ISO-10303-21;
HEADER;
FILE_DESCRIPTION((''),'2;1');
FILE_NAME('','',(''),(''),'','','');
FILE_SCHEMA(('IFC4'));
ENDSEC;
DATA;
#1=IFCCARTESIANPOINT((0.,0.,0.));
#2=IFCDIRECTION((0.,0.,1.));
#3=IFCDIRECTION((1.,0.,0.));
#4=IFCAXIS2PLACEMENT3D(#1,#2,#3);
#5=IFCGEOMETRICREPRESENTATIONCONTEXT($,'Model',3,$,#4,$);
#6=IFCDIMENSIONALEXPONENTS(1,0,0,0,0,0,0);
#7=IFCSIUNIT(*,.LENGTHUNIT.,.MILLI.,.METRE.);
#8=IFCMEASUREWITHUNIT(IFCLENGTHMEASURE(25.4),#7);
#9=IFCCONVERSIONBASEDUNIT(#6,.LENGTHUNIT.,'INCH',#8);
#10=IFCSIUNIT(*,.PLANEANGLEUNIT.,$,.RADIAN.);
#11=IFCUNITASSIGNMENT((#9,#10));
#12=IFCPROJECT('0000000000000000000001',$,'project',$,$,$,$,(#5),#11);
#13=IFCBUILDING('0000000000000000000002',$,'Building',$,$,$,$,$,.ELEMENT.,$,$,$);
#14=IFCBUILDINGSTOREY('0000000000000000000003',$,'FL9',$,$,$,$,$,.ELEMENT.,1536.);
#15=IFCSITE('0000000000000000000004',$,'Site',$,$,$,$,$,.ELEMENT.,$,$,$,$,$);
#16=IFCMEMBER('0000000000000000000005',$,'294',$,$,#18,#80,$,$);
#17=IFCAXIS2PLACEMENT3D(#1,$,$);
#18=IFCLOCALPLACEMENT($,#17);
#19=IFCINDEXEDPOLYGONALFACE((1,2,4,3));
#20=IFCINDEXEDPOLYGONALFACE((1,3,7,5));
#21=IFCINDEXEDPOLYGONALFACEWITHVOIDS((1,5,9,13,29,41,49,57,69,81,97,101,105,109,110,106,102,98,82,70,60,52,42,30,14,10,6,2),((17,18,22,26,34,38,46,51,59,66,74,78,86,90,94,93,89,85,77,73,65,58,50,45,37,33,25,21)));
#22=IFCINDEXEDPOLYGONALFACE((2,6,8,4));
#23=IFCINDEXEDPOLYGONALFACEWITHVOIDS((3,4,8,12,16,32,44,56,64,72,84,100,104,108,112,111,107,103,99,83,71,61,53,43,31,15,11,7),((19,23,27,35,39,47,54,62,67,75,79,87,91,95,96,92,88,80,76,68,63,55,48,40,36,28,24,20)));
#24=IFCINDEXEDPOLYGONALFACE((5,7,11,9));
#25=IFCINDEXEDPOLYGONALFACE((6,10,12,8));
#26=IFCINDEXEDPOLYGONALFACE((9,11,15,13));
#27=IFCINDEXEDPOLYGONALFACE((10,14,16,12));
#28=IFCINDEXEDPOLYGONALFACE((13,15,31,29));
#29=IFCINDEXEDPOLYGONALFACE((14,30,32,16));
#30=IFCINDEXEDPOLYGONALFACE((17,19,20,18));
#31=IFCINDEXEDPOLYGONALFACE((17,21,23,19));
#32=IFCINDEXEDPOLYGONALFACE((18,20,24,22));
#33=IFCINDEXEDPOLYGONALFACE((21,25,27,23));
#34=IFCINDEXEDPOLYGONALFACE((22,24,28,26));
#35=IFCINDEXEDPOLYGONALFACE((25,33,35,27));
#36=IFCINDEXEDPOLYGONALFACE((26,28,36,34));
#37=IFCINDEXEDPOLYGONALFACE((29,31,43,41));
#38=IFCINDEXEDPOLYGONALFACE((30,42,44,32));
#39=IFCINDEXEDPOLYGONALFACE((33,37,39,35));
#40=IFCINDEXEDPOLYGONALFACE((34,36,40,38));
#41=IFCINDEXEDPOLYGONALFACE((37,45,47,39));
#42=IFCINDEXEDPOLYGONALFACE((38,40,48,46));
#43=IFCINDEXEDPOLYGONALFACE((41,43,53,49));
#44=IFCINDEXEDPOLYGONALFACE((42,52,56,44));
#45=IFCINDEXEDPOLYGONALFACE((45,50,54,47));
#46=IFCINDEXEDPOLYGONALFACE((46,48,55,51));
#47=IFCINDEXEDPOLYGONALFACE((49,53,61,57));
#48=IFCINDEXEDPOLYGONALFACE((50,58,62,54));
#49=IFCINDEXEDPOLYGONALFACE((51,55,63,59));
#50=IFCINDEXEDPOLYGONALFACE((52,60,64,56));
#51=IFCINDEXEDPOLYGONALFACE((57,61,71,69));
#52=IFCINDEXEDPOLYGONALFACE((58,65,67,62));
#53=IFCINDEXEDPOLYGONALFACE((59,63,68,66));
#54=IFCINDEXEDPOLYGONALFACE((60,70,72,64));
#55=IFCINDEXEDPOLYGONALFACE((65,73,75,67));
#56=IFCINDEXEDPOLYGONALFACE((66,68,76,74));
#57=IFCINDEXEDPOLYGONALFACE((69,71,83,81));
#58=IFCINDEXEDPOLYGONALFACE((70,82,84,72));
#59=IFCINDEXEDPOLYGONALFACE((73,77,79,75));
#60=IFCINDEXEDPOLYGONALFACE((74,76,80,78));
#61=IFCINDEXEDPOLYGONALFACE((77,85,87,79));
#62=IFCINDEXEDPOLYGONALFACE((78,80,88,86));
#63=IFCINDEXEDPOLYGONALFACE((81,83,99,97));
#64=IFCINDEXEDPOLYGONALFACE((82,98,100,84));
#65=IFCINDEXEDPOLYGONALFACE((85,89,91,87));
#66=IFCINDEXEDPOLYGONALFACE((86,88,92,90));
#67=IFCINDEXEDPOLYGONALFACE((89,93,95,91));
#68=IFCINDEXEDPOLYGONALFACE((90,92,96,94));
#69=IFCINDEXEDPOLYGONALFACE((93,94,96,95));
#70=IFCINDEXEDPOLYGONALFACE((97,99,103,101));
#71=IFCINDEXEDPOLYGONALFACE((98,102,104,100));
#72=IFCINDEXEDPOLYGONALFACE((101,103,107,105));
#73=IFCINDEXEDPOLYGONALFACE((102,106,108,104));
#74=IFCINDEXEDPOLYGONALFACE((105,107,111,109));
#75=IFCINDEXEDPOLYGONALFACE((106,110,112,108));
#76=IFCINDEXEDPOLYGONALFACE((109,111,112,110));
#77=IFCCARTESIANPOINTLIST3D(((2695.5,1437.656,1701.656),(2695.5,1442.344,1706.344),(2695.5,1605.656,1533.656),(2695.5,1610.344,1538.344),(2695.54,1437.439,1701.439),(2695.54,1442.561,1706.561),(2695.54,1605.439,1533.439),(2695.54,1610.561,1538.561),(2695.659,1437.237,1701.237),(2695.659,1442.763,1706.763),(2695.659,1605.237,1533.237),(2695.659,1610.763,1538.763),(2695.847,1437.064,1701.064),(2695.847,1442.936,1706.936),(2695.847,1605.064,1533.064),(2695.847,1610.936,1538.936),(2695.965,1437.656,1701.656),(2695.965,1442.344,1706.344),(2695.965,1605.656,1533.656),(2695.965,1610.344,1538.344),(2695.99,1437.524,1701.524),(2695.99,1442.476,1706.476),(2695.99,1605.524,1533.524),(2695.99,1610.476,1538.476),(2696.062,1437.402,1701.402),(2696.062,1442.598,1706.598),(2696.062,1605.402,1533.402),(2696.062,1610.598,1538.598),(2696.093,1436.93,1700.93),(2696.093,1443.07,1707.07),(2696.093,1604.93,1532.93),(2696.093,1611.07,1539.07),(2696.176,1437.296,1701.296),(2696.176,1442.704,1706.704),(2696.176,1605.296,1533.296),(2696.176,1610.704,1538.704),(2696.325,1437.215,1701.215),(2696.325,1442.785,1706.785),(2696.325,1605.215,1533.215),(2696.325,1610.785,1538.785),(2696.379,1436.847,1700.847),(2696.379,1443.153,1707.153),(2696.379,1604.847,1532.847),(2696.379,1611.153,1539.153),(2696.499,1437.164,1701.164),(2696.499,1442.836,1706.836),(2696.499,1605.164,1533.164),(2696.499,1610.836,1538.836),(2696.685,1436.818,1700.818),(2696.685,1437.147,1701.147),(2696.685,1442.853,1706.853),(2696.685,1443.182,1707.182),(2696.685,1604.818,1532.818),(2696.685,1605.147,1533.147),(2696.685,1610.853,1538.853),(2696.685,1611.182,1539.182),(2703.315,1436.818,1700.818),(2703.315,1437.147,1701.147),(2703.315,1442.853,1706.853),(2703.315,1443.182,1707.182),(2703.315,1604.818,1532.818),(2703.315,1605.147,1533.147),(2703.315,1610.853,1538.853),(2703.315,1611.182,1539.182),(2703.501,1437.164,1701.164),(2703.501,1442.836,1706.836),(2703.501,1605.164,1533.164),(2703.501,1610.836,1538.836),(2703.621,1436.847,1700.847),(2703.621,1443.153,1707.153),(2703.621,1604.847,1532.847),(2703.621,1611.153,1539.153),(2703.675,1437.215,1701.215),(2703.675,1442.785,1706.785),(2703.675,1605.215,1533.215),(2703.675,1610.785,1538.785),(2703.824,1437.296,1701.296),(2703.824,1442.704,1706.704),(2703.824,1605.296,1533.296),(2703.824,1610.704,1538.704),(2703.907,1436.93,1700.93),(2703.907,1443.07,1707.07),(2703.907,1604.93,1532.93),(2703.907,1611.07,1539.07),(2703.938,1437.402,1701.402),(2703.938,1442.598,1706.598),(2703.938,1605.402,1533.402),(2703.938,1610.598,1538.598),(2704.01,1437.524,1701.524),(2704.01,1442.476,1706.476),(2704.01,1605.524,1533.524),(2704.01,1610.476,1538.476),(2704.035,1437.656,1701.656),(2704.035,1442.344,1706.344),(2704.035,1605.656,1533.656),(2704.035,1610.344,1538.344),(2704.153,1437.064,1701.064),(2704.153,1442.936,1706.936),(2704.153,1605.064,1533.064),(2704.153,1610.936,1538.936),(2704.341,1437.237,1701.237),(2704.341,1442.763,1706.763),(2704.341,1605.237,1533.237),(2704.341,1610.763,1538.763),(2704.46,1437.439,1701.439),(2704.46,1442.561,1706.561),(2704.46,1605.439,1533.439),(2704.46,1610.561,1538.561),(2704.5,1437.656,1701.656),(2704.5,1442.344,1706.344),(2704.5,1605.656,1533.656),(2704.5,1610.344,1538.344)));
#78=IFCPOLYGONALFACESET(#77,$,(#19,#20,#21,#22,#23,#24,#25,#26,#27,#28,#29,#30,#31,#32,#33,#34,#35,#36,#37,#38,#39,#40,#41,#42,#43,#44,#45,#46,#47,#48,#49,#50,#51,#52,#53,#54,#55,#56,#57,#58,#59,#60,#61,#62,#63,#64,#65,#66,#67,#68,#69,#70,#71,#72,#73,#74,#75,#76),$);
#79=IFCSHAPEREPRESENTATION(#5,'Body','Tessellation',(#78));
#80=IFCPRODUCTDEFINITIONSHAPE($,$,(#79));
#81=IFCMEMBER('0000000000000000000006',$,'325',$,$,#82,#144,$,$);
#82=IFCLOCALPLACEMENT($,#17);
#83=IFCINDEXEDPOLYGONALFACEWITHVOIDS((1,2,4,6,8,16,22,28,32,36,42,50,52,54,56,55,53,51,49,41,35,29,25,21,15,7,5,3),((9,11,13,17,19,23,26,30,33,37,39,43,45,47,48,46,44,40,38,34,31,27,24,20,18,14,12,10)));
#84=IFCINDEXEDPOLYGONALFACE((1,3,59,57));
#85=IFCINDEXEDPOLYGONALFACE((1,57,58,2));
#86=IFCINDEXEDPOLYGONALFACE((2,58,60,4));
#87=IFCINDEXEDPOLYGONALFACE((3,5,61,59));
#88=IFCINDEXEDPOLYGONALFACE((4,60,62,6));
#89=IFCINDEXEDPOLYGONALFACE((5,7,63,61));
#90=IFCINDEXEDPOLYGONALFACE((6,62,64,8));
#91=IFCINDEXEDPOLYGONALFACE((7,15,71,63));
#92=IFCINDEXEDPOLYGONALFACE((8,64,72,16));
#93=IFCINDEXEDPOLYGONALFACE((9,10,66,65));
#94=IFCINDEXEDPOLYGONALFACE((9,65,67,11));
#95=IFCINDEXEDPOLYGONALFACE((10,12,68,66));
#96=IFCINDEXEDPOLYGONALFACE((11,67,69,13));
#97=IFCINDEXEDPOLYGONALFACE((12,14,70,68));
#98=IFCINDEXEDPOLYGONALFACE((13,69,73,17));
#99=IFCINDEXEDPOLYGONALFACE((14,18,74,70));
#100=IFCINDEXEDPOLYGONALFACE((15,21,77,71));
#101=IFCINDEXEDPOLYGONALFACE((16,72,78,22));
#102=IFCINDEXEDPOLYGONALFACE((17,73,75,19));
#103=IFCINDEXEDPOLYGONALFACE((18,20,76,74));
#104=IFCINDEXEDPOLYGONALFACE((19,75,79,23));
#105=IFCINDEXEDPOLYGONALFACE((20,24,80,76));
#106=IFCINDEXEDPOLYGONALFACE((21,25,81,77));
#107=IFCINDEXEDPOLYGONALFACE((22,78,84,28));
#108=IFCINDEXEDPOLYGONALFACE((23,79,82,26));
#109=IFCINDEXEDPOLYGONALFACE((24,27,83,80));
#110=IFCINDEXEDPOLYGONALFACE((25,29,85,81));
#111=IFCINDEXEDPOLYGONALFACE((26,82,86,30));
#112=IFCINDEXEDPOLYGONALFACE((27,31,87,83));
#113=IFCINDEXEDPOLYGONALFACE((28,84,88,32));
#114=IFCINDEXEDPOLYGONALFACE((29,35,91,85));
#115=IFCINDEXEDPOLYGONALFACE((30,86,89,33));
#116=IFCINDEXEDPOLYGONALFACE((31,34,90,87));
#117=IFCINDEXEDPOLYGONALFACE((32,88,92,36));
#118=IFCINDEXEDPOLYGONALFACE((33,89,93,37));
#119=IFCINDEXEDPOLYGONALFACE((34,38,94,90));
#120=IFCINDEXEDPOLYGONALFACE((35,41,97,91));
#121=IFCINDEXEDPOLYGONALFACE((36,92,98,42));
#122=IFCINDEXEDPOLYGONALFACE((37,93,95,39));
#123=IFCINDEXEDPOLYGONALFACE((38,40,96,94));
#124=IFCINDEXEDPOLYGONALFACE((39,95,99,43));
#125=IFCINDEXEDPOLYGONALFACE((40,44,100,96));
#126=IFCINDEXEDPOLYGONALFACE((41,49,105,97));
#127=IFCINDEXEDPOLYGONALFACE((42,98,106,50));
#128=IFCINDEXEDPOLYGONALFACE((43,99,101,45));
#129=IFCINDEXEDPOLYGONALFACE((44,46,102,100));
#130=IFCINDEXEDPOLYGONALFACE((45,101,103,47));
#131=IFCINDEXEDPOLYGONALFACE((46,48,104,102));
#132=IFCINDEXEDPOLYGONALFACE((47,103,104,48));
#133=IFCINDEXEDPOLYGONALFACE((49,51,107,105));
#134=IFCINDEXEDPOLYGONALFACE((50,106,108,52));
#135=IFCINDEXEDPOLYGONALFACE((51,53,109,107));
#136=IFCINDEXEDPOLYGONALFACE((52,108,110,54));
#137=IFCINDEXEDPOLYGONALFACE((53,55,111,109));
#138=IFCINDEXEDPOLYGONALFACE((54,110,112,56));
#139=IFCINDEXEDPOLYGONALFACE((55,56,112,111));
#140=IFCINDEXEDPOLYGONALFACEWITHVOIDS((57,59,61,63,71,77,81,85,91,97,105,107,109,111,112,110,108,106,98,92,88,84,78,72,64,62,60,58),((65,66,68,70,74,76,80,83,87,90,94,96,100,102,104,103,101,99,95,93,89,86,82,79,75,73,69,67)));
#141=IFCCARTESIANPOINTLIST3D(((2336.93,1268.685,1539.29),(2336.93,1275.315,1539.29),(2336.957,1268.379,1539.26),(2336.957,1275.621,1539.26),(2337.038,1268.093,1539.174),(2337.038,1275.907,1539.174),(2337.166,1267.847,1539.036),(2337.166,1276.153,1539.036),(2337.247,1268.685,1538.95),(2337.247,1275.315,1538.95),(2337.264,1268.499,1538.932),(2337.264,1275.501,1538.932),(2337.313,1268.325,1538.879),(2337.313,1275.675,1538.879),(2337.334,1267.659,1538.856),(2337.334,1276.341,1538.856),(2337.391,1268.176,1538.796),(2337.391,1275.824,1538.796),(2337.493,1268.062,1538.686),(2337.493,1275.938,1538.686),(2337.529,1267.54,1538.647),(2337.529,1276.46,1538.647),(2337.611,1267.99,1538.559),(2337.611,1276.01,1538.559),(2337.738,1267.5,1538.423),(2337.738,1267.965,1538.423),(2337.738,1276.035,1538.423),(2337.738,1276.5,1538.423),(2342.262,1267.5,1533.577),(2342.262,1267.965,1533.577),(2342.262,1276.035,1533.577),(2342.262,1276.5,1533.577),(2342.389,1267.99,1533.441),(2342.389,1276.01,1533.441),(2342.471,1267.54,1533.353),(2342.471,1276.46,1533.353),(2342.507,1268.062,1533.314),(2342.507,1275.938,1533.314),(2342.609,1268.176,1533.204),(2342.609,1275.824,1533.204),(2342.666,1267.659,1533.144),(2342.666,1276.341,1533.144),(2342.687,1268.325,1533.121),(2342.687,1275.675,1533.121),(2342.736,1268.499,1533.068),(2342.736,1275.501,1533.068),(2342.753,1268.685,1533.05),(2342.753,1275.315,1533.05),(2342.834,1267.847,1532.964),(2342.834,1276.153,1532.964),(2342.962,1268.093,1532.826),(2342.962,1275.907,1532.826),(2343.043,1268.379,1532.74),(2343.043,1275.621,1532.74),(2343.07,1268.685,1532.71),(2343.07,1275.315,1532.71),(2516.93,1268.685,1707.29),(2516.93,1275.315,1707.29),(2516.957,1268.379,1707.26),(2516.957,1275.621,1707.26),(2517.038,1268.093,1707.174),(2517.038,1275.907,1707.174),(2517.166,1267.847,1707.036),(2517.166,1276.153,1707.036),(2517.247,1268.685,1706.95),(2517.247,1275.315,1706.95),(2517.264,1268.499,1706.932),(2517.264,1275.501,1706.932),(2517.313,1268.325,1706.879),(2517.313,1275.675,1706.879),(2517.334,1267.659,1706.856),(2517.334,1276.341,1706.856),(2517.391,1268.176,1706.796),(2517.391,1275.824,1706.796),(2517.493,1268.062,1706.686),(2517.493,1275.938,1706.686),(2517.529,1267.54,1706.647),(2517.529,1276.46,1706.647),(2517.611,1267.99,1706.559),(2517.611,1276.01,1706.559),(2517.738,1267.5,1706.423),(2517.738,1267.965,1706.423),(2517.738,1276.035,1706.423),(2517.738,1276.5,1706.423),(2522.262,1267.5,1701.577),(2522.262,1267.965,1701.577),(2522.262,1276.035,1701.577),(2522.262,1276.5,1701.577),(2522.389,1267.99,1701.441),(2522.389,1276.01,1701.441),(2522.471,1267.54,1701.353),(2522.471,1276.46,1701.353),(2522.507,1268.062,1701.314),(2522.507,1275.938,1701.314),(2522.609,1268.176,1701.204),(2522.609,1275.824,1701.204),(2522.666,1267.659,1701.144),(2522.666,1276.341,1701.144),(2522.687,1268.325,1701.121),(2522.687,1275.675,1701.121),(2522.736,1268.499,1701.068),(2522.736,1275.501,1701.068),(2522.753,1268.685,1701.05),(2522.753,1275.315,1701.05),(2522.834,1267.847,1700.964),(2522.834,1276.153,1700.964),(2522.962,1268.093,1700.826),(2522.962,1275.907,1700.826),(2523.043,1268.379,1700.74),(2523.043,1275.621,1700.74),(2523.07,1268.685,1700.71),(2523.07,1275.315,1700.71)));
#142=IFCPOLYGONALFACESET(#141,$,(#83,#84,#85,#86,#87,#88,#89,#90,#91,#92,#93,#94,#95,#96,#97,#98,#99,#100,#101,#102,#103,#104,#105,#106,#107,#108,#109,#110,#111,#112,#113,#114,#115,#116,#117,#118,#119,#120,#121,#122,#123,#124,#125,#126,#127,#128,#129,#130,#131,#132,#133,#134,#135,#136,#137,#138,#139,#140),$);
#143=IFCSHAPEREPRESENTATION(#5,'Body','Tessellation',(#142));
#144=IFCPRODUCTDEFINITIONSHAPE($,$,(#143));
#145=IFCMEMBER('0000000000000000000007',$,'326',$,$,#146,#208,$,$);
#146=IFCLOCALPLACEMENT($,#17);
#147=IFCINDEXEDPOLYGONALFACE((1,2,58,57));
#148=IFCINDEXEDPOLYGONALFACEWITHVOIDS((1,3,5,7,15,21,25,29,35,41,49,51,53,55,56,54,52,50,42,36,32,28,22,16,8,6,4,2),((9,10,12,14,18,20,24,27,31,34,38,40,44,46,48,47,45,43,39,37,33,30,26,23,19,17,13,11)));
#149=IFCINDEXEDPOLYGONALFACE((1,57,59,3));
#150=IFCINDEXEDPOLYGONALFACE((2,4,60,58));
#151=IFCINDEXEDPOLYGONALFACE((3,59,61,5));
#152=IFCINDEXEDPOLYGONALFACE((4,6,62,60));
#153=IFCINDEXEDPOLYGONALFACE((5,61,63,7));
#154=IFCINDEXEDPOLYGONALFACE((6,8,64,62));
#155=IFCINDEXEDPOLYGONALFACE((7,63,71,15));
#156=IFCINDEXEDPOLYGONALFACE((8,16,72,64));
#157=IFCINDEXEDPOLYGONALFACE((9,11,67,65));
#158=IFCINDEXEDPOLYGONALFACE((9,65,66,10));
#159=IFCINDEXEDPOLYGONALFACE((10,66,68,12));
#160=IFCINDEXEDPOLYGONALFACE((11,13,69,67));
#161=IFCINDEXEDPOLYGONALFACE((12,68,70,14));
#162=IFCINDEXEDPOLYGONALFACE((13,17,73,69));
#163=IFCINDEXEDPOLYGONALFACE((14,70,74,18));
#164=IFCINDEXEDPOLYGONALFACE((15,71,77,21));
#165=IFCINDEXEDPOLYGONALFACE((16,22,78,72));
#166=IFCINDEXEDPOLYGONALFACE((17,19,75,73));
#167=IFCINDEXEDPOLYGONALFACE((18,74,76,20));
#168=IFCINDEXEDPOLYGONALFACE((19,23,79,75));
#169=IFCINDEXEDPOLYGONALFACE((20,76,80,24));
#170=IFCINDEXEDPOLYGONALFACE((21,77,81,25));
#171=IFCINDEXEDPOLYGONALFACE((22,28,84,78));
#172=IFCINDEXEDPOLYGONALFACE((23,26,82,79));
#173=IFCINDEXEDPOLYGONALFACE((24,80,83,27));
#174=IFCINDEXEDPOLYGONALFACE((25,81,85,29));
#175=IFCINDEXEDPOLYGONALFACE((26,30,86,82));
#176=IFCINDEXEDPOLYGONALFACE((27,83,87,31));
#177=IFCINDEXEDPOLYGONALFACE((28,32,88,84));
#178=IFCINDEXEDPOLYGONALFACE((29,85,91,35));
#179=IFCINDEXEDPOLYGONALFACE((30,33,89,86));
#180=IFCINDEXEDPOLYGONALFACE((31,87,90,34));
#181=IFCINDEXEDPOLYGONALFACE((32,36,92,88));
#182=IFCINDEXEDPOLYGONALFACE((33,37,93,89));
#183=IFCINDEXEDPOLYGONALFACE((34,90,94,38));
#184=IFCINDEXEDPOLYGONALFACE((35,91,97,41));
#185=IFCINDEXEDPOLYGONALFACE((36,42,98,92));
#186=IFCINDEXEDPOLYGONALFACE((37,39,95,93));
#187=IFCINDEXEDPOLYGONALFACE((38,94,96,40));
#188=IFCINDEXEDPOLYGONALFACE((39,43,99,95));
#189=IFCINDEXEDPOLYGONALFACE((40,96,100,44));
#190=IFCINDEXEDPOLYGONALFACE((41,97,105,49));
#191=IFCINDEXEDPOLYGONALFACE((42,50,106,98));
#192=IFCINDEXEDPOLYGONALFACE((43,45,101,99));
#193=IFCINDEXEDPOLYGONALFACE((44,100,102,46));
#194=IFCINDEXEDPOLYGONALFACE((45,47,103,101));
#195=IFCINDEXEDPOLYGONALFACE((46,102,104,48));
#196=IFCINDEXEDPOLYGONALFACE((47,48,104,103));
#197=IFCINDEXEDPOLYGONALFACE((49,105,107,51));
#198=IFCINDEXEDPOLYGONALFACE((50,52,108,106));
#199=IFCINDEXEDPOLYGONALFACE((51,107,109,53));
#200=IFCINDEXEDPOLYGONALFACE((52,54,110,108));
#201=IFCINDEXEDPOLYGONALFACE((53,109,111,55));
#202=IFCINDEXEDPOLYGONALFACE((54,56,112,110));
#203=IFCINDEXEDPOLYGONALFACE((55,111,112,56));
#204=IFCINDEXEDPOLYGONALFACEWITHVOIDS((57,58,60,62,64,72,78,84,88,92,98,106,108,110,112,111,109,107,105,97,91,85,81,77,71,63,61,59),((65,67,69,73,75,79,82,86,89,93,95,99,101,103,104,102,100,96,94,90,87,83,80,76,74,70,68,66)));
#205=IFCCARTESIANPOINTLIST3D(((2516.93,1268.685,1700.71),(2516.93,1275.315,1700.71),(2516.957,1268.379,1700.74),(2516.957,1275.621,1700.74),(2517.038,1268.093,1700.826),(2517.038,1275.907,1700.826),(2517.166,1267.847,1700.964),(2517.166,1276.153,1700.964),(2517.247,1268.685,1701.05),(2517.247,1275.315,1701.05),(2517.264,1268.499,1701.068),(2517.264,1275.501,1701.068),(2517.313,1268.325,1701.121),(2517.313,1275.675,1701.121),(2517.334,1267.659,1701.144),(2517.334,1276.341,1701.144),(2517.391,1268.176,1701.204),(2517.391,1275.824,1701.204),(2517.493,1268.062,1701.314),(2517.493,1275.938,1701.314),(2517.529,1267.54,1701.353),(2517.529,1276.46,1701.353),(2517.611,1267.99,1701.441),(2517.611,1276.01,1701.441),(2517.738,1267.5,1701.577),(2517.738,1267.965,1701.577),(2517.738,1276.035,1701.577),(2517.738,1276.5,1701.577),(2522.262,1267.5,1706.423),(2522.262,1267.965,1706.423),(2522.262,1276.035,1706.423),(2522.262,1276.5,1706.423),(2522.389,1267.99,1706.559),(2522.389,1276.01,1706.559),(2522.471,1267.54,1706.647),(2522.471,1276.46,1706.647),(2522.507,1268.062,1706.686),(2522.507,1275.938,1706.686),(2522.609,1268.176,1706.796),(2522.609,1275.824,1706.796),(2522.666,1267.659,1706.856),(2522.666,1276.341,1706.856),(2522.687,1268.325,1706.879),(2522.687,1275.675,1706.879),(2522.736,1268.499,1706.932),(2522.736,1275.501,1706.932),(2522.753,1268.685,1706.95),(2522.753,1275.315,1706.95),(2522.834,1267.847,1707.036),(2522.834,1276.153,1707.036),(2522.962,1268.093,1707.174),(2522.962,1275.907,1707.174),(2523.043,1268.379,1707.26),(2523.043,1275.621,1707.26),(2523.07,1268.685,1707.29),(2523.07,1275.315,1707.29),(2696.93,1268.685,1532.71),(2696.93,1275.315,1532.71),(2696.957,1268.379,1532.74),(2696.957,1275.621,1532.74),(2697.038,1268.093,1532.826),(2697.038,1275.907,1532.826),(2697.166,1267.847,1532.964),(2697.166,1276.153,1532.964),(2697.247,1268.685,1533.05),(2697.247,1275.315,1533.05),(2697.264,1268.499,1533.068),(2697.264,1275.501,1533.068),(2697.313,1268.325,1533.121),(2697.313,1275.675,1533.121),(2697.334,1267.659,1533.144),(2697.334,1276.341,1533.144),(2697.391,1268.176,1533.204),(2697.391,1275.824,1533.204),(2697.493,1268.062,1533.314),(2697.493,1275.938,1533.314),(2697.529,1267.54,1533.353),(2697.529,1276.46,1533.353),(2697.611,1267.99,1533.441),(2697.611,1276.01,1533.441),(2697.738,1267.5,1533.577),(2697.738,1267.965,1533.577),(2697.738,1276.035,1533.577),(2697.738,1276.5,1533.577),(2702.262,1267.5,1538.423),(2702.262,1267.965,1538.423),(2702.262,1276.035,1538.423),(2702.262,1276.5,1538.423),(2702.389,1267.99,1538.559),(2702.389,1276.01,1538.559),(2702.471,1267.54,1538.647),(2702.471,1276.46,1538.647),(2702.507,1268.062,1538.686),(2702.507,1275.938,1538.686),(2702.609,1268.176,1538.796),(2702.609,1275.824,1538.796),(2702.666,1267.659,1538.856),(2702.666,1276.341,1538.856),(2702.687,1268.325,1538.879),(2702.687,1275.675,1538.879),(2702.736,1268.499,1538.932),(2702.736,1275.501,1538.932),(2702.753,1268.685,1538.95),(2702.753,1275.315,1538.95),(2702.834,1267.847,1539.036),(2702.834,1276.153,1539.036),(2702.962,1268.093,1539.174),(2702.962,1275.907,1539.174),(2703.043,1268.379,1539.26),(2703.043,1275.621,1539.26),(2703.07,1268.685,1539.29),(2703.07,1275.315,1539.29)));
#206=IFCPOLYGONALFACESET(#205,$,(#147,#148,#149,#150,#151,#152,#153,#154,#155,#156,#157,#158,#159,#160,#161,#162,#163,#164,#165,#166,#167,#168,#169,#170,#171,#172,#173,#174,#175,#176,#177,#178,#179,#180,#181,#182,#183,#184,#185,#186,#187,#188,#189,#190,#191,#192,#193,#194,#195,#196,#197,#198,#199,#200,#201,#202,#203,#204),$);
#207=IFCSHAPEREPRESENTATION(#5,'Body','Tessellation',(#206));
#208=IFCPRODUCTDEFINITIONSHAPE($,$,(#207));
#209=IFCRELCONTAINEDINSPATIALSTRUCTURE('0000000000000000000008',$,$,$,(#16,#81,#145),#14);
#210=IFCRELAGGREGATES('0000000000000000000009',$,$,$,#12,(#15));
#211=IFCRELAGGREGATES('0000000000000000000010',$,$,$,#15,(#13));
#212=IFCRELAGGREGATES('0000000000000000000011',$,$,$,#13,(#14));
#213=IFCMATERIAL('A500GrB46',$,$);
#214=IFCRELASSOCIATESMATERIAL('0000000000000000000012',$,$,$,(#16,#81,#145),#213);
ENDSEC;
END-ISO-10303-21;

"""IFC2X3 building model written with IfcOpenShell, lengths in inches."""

from ifc_helpers import new_model, entity, si_unit, converted_unit, frame, origin_with_axes, origin_2d_with_axis, place, context, project, spatial, hollow_rectangle, extrude, material, element, save


model = new_model("IFC2X3")

# Units and contexts
model_context = context("Model", 3, world=origin_with_axes())
ifc_project = project(units=[converted_unit("LENGTHUNIT", "INCH", entity("IfcLengthMeasure", 25.4), si_unit("LENGTHUNIT", "METRE", prefix="MILLI"), dimensions=[1, 0, 0, 0, 0, 0, 0]), si_unit("PLANEANGLEUNIT", "RADIAN")], contexts=[model_context])

# Site, building, storey
site = spatial("IfcSite", under=ifc_project, Name="Site", CompositionType="ELEMENT")
building = spatial("IfcBuilding", under=site, Name="Building", CompositionType="ELEMENT")
storey = spatial("IfcBuildingStorey", under=building, Name="FL9", CompositionType="ELEMENT", Elevation=1536.0)

# Members
ifc_material_1 = material(Name="A500GrB46")
for number, where, z_axis, x_axis, name in (
    (1, (2700.0, 1608.0, 1536.0), (0.0, -0.707107, 0.707107), (1.0, 0.0, 0.0), "294"),
):
    element("IfcMember", number, at=place(None, frame(where, z_axis=z_axis, x_axis=x_axis)), inside=storey, material=ifc_material_1, Name=name, context=model_context, shape_type="SweptSolid", body=[
        extrude(hollow_rectangle(XDim=9.0, YDim=9.0, WallThickness=0.465, InnerFilletRadius=0.72, OuterFilletRadius=1.185, at=origin_2d_with_axis()), origin_with_axes(), (0.0, 0.0, 1.0), 237.588),
    ])
for number, where, z_axis, x_axis, name in (
    (2, (2340.0, 1272.0, 1536.0), (0.731055, 0.0, 0.682318), (0.0, 1.0, 0.0), "325"),
    (3, (2700.0, 1272.0, 1536.0), (-0.731055, 0.0, 0.682318), (0.0, -1.0, 0.0), "326"),
):
    element("IfcMember", number, at=place(None, frame(where, z_axis=z_axis, x_axis=x_axis)), inside=storey, material=ifc_material_1, Name=name, context=model_context, shape_type="SweptSolid", body=[
        extrude(hollow_rectangle(XDim=9.0, YDim=9.0, WallThickness=0.465, InnerFilletRadius=0.72, OuterFilletRadius=1.185, at=origin_2d_with_axis()), origin_with_axes(), (0.0, 0.0, 1.0), 246.219),
    ])

save(model, "model.ifc")
